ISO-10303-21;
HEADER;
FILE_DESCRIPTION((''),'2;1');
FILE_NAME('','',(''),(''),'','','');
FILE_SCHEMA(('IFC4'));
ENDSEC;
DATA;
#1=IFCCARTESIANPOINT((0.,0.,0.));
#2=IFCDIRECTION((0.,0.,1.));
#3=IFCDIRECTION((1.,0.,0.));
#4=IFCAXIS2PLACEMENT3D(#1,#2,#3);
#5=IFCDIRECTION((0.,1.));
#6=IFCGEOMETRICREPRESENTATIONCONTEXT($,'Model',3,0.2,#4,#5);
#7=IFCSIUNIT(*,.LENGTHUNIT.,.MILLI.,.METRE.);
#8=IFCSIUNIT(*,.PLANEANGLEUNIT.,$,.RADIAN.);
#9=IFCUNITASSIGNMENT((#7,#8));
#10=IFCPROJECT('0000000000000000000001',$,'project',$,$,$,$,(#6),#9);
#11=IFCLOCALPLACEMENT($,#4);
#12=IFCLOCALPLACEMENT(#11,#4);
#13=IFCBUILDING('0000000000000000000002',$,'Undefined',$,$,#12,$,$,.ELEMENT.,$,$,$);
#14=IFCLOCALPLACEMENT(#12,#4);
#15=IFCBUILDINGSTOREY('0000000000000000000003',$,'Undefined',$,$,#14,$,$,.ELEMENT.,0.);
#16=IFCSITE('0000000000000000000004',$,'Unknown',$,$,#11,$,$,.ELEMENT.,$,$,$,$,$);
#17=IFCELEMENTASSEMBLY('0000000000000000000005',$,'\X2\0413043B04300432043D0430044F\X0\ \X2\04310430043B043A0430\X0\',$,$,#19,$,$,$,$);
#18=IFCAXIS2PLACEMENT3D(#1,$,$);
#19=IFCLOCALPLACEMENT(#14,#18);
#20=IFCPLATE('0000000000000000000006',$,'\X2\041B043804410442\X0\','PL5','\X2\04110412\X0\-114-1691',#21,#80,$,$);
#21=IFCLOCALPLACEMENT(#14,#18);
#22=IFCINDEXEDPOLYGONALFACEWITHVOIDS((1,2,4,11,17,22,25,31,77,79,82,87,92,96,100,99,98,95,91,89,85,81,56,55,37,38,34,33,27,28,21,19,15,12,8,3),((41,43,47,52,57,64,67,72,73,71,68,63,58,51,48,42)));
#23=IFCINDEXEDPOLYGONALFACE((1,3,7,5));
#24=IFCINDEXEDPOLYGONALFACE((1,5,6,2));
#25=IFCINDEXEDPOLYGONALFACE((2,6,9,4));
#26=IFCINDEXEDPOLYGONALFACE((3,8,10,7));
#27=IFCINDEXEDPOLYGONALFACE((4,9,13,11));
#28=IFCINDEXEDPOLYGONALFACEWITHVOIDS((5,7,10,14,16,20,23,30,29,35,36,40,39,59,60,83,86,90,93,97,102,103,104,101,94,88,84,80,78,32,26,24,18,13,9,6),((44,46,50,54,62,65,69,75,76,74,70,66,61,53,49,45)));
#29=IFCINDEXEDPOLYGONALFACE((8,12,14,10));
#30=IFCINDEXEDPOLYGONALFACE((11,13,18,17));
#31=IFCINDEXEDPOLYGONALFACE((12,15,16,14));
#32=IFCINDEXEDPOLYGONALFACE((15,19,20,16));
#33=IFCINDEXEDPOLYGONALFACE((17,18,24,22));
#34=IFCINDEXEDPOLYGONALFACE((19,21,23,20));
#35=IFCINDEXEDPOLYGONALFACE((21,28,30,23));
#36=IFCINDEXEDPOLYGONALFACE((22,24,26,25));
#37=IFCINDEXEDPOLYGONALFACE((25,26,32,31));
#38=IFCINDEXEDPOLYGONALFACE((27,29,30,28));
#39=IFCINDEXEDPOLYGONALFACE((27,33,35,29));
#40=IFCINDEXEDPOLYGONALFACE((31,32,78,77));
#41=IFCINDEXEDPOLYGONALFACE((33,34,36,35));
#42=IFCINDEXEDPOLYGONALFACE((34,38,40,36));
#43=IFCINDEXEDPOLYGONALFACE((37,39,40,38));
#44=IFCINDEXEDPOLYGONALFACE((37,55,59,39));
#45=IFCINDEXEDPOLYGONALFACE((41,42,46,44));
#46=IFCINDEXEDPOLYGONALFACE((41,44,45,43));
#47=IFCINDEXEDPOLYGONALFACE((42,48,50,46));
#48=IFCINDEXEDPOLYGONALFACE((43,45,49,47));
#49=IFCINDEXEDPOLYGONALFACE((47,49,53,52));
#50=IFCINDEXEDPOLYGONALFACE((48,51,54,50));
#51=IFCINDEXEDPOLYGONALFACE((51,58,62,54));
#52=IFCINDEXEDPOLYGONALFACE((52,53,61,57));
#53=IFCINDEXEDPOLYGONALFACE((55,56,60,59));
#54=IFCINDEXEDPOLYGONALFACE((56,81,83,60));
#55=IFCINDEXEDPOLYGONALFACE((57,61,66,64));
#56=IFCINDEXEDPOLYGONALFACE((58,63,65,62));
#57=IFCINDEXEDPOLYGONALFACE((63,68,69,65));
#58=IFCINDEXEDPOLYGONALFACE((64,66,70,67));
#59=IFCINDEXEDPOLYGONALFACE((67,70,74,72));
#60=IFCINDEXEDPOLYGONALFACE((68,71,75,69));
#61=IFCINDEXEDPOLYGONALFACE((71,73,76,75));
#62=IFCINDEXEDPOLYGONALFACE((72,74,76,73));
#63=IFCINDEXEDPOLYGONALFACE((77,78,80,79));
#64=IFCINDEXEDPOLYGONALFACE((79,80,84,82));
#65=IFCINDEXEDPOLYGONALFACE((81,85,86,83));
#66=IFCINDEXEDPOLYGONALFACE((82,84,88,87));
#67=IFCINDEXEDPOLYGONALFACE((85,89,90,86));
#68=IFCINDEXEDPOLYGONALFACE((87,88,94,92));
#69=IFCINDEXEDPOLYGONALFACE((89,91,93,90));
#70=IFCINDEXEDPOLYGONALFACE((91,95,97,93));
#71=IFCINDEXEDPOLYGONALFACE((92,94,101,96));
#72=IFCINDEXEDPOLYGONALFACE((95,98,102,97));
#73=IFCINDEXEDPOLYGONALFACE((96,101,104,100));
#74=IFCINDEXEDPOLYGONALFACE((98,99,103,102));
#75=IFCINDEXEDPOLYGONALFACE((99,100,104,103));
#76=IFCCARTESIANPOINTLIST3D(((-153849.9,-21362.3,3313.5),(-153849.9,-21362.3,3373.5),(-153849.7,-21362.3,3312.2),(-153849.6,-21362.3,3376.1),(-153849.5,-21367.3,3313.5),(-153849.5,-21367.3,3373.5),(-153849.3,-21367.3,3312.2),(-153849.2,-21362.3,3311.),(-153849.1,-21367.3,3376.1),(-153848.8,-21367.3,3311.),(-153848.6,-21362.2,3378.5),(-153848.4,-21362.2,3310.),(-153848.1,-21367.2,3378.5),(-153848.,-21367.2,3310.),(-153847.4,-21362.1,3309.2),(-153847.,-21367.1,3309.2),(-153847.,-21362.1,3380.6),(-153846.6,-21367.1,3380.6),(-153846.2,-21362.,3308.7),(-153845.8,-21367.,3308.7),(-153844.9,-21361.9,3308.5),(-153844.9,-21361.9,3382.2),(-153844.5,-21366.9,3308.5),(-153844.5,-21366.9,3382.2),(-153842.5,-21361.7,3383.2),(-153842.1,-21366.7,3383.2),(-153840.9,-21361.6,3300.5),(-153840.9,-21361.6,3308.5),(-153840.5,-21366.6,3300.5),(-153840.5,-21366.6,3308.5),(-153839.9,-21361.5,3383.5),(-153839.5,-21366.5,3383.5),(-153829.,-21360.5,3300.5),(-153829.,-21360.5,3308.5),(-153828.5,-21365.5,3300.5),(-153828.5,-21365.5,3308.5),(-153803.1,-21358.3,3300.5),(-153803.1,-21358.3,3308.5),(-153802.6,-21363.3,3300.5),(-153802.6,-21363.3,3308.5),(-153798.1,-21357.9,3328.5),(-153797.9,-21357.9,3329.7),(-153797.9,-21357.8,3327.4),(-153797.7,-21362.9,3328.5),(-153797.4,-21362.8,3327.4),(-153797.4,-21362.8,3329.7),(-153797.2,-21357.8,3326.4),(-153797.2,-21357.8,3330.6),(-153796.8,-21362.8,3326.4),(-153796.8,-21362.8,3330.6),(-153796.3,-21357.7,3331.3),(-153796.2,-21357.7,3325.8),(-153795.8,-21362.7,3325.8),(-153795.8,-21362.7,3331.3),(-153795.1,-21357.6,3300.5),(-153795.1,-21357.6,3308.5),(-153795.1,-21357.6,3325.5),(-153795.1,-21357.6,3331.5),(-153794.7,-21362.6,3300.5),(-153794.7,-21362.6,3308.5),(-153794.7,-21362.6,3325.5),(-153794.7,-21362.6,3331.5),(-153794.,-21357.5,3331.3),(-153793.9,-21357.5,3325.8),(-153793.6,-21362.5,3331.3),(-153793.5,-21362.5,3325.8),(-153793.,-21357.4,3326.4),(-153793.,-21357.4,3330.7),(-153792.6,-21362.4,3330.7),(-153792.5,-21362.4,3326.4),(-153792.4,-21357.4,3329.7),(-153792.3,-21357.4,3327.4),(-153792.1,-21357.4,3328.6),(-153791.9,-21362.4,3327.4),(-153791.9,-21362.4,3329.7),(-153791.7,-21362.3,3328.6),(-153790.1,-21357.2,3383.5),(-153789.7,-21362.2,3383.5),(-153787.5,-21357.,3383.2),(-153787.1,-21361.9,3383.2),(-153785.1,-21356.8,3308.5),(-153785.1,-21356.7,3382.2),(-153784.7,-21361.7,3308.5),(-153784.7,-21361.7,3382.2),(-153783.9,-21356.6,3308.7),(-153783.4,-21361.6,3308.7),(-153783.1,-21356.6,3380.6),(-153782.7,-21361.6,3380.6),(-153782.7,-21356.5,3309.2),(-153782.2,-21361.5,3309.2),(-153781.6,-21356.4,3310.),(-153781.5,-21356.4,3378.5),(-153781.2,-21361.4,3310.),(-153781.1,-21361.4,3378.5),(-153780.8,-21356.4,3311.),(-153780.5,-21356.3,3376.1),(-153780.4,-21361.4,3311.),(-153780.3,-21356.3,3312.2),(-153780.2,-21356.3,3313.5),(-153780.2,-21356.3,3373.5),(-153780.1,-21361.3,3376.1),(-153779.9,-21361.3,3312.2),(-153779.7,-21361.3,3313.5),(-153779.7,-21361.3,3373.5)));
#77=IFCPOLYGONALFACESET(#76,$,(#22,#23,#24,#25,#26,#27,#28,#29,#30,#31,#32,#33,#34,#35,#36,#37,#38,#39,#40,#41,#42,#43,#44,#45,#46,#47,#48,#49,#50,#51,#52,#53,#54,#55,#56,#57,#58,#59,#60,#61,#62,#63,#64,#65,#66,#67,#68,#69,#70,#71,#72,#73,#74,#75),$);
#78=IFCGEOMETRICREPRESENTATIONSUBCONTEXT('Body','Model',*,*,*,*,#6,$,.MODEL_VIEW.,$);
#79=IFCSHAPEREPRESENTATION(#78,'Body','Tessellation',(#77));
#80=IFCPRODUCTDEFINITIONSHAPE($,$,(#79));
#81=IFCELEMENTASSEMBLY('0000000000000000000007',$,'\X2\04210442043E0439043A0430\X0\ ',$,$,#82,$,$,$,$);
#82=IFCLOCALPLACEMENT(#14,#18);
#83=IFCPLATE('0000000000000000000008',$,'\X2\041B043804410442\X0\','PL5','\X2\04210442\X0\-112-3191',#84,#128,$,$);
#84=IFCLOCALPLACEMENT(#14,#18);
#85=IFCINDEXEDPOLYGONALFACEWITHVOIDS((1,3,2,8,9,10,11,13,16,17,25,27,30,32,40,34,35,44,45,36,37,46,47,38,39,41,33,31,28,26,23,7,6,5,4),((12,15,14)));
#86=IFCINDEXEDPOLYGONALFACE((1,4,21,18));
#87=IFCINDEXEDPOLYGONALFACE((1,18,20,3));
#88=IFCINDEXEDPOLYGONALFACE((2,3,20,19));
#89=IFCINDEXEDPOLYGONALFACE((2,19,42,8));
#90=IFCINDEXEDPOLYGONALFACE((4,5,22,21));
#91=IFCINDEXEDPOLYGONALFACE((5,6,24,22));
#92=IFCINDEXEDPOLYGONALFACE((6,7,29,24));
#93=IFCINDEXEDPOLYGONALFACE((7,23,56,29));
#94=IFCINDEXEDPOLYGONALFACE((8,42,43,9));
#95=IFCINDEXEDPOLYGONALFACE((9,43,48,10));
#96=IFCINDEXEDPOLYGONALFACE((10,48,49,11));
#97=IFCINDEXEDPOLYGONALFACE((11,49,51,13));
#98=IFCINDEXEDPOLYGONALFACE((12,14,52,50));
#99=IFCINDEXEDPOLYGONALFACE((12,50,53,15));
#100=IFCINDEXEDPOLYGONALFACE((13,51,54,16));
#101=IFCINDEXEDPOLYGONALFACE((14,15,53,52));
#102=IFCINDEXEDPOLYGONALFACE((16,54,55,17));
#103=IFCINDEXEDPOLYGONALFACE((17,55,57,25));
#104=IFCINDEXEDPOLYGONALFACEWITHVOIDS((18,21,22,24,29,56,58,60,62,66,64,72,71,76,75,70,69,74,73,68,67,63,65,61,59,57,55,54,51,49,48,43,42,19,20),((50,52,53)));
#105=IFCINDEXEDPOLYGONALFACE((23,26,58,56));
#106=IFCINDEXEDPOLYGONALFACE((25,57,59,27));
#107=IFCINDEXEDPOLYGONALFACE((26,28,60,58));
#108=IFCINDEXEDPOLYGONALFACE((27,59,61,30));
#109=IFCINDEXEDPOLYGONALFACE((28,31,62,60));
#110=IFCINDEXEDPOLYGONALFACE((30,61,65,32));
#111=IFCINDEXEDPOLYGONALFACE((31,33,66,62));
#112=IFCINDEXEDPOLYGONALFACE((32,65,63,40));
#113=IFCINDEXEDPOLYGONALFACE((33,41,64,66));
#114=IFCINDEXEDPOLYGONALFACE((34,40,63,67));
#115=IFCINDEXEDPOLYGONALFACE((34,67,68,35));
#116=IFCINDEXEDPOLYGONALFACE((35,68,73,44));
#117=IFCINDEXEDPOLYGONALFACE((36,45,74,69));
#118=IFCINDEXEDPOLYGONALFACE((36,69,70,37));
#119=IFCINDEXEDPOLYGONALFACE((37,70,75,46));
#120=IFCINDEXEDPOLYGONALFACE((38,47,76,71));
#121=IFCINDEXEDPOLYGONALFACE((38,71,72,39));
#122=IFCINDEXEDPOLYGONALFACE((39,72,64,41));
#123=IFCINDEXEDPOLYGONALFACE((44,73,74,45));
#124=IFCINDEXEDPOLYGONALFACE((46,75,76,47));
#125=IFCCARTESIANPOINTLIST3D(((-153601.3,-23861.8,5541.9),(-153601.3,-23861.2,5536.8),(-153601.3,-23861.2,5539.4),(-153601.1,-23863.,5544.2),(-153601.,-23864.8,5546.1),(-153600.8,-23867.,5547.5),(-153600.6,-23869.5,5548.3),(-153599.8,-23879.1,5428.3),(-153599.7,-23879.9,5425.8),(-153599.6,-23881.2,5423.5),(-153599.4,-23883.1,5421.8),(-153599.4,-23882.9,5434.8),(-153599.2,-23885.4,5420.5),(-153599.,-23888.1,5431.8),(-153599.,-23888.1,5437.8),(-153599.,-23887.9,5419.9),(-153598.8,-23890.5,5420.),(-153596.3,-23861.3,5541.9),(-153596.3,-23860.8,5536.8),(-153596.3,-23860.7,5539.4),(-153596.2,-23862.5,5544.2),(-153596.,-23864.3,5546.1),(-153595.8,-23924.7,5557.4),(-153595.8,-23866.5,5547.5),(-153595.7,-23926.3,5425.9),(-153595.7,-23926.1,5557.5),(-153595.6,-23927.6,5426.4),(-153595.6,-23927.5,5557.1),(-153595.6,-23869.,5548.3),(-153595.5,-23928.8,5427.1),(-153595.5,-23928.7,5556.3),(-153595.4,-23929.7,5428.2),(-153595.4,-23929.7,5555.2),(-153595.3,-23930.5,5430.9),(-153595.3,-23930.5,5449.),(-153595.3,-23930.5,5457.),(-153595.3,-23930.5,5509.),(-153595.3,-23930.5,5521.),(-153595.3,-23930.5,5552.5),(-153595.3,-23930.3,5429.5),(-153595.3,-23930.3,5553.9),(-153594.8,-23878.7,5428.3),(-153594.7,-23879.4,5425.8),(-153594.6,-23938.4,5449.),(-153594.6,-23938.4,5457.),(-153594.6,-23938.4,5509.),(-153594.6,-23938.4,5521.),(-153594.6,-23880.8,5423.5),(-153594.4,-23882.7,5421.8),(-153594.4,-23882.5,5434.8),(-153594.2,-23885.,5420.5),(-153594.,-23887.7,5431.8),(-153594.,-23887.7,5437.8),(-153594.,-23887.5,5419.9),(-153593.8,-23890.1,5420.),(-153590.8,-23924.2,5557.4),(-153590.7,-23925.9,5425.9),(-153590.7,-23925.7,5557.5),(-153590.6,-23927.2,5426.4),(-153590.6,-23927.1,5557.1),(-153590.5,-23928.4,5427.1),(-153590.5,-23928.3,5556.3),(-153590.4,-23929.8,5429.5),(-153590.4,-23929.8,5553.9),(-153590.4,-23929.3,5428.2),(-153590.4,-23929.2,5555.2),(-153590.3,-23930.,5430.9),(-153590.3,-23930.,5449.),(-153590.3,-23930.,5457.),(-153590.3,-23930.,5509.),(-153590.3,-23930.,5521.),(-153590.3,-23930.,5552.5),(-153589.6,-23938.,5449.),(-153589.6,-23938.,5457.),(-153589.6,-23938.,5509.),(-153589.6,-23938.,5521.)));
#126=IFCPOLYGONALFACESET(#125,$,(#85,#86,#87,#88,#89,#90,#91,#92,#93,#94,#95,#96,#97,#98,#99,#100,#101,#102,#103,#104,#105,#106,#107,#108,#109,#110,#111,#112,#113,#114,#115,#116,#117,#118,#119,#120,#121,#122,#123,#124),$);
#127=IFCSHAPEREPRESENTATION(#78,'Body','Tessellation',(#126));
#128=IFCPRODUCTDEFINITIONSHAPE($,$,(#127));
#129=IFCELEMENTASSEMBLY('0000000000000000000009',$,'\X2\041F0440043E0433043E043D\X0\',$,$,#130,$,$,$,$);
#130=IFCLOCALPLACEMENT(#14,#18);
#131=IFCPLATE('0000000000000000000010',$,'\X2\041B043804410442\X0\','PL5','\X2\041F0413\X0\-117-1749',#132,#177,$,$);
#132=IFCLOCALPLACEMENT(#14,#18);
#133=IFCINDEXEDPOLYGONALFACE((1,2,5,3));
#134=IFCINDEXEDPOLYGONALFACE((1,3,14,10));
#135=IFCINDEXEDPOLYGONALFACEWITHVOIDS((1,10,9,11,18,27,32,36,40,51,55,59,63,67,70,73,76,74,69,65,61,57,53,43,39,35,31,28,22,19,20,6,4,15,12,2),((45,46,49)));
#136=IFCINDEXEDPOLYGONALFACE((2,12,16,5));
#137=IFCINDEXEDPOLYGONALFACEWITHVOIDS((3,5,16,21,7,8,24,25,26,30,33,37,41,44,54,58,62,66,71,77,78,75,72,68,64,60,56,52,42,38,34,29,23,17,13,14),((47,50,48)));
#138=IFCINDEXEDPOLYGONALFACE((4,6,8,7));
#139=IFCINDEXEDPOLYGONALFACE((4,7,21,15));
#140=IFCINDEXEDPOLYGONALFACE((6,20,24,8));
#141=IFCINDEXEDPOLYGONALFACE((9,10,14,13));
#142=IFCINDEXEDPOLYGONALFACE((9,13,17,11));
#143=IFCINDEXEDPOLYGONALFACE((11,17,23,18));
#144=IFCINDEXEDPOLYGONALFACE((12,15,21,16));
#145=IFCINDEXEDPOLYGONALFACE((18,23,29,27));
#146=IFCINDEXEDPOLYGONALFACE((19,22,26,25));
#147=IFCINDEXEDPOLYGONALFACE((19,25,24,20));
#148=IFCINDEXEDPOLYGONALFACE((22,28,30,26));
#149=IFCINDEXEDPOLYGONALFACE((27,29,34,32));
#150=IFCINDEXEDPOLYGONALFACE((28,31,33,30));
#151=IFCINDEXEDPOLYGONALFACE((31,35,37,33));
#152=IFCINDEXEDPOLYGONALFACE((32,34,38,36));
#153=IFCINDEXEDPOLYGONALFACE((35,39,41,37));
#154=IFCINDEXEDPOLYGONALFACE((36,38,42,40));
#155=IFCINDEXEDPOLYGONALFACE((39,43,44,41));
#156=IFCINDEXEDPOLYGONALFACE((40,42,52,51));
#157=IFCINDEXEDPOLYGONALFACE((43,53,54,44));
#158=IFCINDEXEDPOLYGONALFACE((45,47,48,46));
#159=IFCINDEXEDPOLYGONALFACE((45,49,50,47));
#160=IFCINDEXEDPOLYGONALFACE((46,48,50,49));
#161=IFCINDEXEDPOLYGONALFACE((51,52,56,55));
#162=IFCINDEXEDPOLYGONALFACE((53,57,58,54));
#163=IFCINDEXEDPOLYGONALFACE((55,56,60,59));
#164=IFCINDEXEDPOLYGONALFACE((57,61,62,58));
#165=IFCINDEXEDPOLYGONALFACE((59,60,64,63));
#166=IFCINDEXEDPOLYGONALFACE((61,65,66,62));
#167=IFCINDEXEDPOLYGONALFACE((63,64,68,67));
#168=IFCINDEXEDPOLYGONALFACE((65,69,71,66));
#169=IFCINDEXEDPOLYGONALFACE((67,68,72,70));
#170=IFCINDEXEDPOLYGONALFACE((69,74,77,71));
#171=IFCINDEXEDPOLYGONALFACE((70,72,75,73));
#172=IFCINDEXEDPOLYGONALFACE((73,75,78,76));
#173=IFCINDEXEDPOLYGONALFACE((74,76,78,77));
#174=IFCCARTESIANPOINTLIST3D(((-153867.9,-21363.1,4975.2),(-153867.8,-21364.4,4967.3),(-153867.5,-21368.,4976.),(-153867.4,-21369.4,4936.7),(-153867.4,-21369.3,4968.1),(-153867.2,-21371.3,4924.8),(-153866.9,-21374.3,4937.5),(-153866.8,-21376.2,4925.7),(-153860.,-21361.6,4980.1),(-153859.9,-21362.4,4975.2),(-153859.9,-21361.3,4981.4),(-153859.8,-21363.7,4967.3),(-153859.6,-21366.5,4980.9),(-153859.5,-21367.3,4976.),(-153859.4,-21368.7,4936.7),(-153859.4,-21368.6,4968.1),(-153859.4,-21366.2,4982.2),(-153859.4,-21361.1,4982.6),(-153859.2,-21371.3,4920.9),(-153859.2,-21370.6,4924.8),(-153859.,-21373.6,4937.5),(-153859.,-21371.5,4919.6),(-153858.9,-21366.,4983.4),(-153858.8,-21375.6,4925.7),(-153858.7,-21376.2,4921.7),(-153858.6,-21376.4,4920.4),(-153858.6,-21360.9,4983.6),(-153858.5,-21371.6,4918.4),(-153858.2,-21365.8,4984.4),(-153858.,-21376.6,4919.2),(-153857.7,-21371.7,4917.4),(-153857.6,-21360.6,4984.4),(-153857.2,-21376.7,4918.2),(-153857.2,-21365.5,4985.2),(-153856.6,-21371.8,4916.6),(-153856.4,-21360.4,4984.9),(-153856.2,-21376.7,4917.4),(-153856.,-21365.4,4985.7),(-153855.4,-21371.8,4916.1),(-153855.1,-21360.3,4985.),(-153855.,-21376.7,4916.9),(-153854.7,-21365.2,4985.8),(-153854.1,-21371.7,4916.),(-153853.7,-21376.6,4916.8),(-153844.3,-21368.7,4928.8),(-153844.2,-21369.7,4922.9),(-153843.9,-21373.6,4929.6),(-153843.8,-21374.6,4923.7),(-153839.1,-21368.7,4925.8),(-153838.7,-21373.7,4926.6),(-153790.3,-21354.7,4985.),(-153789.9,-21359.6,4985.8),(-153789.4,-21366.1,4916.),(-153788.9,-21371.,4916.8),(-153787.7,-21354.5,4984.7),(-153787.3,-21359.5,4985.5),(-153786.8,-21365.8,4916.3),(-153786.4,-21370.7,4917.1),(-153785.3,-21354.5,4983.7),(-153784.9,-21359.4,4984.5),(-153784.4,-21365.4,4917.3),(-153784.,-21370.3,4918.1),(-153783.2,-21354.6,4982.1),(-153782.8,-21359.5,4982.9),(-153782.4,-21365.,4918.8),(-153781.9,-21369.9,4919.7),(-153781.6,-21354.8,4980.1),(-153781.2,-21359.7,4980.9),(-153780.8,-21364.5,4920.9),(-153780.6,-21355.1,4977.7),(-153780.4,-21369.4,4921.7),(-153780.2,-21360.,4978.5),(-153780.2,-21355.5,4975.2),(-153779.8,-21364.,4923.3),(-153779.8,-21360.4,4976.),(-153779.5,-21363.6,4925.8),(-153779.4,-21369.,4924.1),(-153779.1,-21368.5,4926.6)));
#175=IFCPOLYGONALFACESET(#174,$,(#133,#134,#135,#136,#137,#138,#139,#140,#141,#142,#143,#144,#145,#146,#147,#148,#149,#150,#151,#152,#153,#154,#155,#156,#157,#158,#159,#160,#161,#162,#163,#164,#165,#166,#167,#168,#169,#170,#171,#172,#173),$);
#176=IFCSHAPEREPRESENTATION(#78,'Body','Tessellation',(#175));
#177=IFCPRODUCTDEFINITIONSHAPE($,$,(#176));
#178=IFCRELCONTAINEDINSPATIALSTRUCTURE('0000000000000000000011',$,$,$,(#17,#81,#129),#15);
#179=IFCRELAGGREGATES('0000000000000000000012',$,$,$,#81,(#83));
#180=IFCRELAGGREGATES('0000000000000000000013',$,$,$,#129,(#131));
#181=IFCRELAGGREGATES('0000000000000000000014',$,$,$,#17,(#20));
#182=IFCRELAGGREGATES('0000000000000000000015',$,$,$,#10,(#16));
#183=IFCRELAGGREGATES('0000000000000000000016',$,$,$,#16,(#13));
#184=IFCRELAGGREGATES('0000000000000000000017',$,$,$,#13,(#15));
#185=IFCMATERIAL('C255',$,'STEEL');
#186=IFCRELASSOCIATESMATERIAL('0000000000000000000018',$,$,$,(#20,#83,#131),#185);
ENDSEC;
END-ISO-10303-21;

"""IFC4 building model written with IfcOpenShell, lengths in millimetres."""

from ifc_helpers import new_model, si_unit, direction, frame, origin_with_axes, place, context, subcontext, project, spatial, line, arc, indexed_curve, outline, extrude, material, element, aggregate, save


model = new_model("IFC4")

# Units and contexts
model_context = context("Model", 3, precision=0.2, world=origin_with_axes(), true_north=direction((0.0, 1.0)))
body_context = subcontext(model_context, "Body", "Model", "MODEL_VIEW")
ifc_project = project(units=[si_unit("LENGTHUNIT", "METRE", prefix="MILLI"), si_unit("PLANEANGLEUNIT", "RADIAN")], contexts=[model_context])

# Site, building, storey
site_placement = place(None, origin_with_axes())
site = spatial("IfcSite", under=ifc_project, at=site_placement, Name="Unknown", CompositionType="ELEMENT")
building_placement = place(site_placement, origin_with_axes())
building = spatial("IfcBuilding", under=site, at=building_placement, Name="Undefined", CompositionType="ELEMENT")
storey_placement = place(building_placement, origin_with_axes())
storey = spatial("IfcBuildingStorey", under=building, at=storey_placement, Name="Undefined", CompositionType="ELEMENT", Elevation=0.0)

# Shared definitions
ifc_material_1 = material(Name="C255", Category="STEEL")

# Element assembly, plate, voiding feature
assembly_1_placement = place(storey_placement, frame((-153597.5, -23933.9, 3248.5), z_axis=(-0.996285, -0.086114, -0.000024), x_axis=(-0.086114, 0.996285, 0.0)))
assembly_1 = element("IfcElementAssembly", 1, at=assembly_1_placement, inside=storey, Name="Главная балка")
plate_1_placement = place(assembly_1_placement, frame((2581.2, -135.0, -40.0), z_axis=(-1.0, -0.000054, 0.0), x_axis=(0.0, 0.000054, 1.0)))
plate_1 = element("IfcPlate", 2, at=plate_1_placement, material=ifc_material_1, Name="Лист", Description="PL5", ObjectType="БВ-114-1691", context=body_context, shape_type="SolidModel", body=[
    extrude(outline(indexed_curve([(0.0, 10.0), (2.9, 2.9), (10.0, 0.0), (60.0, 0.0), (67.1, 2.9), (70.0, 10.0), (70.0, 70.0), (68.5, 73.5), (65.0, 75.0), (61.0, 75.0), (61.0, 83.0), (49.0, 83.0), (49.0, 75.0), (23.0, 75.0), (23.0, 83.0), (15.0, 83.0), (15.0, 75.0), (5.0, 75.0), (1.5, 73.5), (0.0, 70.0)], segments=[arc(1, 2, 3), line(3, 4), arc(4, 5, 6), line(6, 7), arc(7, 8, 9), line(9, 10, 11, 12, 13, 14, 15, 16, 17, 18), arc(18, 19, 20), line(20, 1)])), frame((0.0, 0.0, 2.5), z_axis=(0.0, 0.0, 1.0), x_axis=(1.0, 0.0, 0.0)), (0.0, 0.0, -1.0), 5.0),
])
voiding_feature_1_placement = place(plate_1_placement, frame((15.0, 55.0, 10.0), z_axis=(0.007997, -0.999968, -0.000026), x_axis=(0.0, 0.000026, -1.0)))
element("IfcVoidingFeature", 3, at=voiding_feature_1_placement, cuts=plate_1, Name="Балка", ObjectType="(?)", PredefinedType="HOLE", context=body_context, shape_type="SolidModel", body=[
    extrude(outline(indexed_curve([(3.0, 0.0), (2.8, 1.1), (2.1, 2.1), (1.1, 2.8), (0.0, 3.0), (-1.1, 2.8), (-2.1, 2.1), (-2.8, 1.1), (-3.0, 0.0), (-2.8, -1.1), (-2.1, -2.1), (-1.1, -2.8), (0.0, -3.0), (1.1, -2.8), (2.1, -2.1), (2.8, -1.1)], segments=[line(1, 2, 3, 4, 5, 6, 7, 8, 9, 10, 11, 12, 13, 14, 15, 16, 1)])), frame((0.0, 0.0, 0.0), z_axis=(-1.0, 0.0, 0.0), x_axis=(0.0, 0.0, 1.0)), (0.0, 0.0, -1.0), 20.0),
])

# Element assembly, plate, voiding feature
assembly_2_placement = place(storey_placement, frame((-153594.3, -23970.7, 3672.5), z_axis=(-0.086114, 0.996285, 0.0), x_axis=(0.0, 0.0, 1.0)))
assembly_2 = element("IfcElementAssembly", 4, at=assembly_2_placement, inside=storey, Name="Стойка ")
plate_2_placement = place(assembly_2_placement, frame((1745.9, 5.0, 90.1), z_axis=(-0.000024, 1.0, 0.0), x_axis=(0.986646, 0.000024, 0.162881)))
plate_2 = element("IfcPlate", 5, at=plate_2_placement, material=ifc_material_1, Name="Лист", Description="PL5", ObjectType="Ст-112-3191", context=body_context, shape_type="SolidModel", body=[
    extrude(outline(indexed_curve([(0.0, 10.0), (2.9, 2.9), (10.0, 0.0), (120.0, 0.0), (127.1, 2.9), (130.0, 10.0), (130.0, 66.2), (128.2, 70.0), (124.2, 71.1), (93.2, 66.0), (91.9, 73.9), (80.0, 71.9), (81.3, 64.0), (30.0, 55.6), (28.7, 63.5), (20.8, 62.2), (22.1, 54.3), (4.2, 51.3), (1.2, 49.6), (0.0, 46.4)], segments=[arc(1, 2, 3), line(3, 4), arc(4, 5, 6), line(6, 7), arc(7, 8, 9), line(9, 10, 11, 12, 13, 14, 15, 16, 17, 18), arc(18, 19, 20), line(20, 1)])), frame((0.0, 0.0, 2.5), z_axis=(0.0, 0.0, 1.0), x_axis=(1.0, 0.0, 0.0)), (0.0, 0.0, -1.0), 5.0),
])
voiding_feature_2_placement = place(plate_2_placement, frame((15.0, 10.0, 10.0), z_axis=(0.165862, -0.986149, 0.0), x_axis=(0.0, 0.0, -1.0)))
element("IfcVoidingFeature", 6, at=voiding_feature_2_placement, cuts=plate_2, Name="Балка", ObjectType="(?)", PredefinedType="HOLE", context=body_context, shape_type="SolidModel", body=[
    extrude(outline(indexed_curve([(0.0, -3.0), (5.2, 0.0), (0.0, 3.0)], segments=[line(1, 2, 3, 1)])), frame((0.0, 0.0, 0.0), z_axis=(-1.0, 0.0, 0.0), x_axis=(0.0, 0.0, 1.0)), (0.0, 0.0, -1.0), 20.0),
])

# Element assembly, plate, voiding feature
assembly_3_placement = place(storey_placement, frame((-153899.1, -21374.1, 3248.5), z_axis=(0.086114, -0.996285, 0.0), x_axis=(0.0, 0.0, 1.0)))
assembly_3 = element("IfcElementAssembly", 7, at=assembly_3_placement, inside=storey, Name="Прогон")
plate_3_placement = place(assembly_3_placement, frame((1736.9, -120.0, -7.5), z_axis=(-0.162881, -0.000054, -0.986646), x_axis=(-0.986646, 0.000078, 0.162881)))
plate_3 = element("IfcPlate", 8, at=plate_3_placement, material=ifc_material_1, Name="Лист", Description="PL5", ObjectType="ПГ-117-1749", context=body_context, shape_type="SolidModel", body=[
    extrude(outline(indexed_curve([(0.0, 10.0), (2.9, 2.9), (10.0, 0.0), (60.0, 0.0), (67.1, 2.9), (70.0, 10.0), (70.0, 75.0), (68.5, 78.5), (65.0, 80.0), (61.0, 80.0), (61.0, 88.0), (49.0, 88.0), (49.0, 80.0), (18.0, 80.0), (18.0, 88.0), (10.0, 88.0), (10.0, 80.0), (5.0, 80.0), (1.5, 78.5), (0.0, 75.0)], segments=[arc(1, 2, 3), line(3, 4), arc(4, 5, 6), line(6, 7), arc(7, 8, 9), line(9, 10, 11, 12, 13, 14, 15, 16, 17, 18), arc(18, 19, 20), line(20, 1)])), frame((0.0, 0.0, 2.5), z_axis=(0.0, 0.0, 1.0), x_axis=(1.0, 0.0, 0.0)), (0.0, 0.0, -1.0), 5.0),
])
voiding_feature_3_placement = place(plate_3_placement, frame((60.0, 65.0, 6.0), z_axis=(-0.000054, -1.0, 0.000034), x_axis=(0.0, -0.000034, -1.0)))
element("IfcVoidingFeature", 9, at=voiding_feature_3_placement, cuts=plate_3, Name="Балка", ObjectType="(?)", PredefinedType="HOLE", context=body_context, shape_type="SolidModel", body=[
    extrude(outline(indexed_curve([(0.0, -3.0), (5.2, 0.0), (0.0, 3.0)], segments=[line(1, 2, 3, 1)])), frame((0.0, 0.0, 0.0), z_axis=(-1.0, 0.0, 0.0), x_axis=(0.0, 0.0, 1.0)), (0.0, 0.0, -1.0), 12.0),
])

aggregate(assembly_2, [plate_2])

aggregate(assembly_3, [plate_3])
aggregate(assembly_1, [plate_1])

save(model, "model.ifc")
